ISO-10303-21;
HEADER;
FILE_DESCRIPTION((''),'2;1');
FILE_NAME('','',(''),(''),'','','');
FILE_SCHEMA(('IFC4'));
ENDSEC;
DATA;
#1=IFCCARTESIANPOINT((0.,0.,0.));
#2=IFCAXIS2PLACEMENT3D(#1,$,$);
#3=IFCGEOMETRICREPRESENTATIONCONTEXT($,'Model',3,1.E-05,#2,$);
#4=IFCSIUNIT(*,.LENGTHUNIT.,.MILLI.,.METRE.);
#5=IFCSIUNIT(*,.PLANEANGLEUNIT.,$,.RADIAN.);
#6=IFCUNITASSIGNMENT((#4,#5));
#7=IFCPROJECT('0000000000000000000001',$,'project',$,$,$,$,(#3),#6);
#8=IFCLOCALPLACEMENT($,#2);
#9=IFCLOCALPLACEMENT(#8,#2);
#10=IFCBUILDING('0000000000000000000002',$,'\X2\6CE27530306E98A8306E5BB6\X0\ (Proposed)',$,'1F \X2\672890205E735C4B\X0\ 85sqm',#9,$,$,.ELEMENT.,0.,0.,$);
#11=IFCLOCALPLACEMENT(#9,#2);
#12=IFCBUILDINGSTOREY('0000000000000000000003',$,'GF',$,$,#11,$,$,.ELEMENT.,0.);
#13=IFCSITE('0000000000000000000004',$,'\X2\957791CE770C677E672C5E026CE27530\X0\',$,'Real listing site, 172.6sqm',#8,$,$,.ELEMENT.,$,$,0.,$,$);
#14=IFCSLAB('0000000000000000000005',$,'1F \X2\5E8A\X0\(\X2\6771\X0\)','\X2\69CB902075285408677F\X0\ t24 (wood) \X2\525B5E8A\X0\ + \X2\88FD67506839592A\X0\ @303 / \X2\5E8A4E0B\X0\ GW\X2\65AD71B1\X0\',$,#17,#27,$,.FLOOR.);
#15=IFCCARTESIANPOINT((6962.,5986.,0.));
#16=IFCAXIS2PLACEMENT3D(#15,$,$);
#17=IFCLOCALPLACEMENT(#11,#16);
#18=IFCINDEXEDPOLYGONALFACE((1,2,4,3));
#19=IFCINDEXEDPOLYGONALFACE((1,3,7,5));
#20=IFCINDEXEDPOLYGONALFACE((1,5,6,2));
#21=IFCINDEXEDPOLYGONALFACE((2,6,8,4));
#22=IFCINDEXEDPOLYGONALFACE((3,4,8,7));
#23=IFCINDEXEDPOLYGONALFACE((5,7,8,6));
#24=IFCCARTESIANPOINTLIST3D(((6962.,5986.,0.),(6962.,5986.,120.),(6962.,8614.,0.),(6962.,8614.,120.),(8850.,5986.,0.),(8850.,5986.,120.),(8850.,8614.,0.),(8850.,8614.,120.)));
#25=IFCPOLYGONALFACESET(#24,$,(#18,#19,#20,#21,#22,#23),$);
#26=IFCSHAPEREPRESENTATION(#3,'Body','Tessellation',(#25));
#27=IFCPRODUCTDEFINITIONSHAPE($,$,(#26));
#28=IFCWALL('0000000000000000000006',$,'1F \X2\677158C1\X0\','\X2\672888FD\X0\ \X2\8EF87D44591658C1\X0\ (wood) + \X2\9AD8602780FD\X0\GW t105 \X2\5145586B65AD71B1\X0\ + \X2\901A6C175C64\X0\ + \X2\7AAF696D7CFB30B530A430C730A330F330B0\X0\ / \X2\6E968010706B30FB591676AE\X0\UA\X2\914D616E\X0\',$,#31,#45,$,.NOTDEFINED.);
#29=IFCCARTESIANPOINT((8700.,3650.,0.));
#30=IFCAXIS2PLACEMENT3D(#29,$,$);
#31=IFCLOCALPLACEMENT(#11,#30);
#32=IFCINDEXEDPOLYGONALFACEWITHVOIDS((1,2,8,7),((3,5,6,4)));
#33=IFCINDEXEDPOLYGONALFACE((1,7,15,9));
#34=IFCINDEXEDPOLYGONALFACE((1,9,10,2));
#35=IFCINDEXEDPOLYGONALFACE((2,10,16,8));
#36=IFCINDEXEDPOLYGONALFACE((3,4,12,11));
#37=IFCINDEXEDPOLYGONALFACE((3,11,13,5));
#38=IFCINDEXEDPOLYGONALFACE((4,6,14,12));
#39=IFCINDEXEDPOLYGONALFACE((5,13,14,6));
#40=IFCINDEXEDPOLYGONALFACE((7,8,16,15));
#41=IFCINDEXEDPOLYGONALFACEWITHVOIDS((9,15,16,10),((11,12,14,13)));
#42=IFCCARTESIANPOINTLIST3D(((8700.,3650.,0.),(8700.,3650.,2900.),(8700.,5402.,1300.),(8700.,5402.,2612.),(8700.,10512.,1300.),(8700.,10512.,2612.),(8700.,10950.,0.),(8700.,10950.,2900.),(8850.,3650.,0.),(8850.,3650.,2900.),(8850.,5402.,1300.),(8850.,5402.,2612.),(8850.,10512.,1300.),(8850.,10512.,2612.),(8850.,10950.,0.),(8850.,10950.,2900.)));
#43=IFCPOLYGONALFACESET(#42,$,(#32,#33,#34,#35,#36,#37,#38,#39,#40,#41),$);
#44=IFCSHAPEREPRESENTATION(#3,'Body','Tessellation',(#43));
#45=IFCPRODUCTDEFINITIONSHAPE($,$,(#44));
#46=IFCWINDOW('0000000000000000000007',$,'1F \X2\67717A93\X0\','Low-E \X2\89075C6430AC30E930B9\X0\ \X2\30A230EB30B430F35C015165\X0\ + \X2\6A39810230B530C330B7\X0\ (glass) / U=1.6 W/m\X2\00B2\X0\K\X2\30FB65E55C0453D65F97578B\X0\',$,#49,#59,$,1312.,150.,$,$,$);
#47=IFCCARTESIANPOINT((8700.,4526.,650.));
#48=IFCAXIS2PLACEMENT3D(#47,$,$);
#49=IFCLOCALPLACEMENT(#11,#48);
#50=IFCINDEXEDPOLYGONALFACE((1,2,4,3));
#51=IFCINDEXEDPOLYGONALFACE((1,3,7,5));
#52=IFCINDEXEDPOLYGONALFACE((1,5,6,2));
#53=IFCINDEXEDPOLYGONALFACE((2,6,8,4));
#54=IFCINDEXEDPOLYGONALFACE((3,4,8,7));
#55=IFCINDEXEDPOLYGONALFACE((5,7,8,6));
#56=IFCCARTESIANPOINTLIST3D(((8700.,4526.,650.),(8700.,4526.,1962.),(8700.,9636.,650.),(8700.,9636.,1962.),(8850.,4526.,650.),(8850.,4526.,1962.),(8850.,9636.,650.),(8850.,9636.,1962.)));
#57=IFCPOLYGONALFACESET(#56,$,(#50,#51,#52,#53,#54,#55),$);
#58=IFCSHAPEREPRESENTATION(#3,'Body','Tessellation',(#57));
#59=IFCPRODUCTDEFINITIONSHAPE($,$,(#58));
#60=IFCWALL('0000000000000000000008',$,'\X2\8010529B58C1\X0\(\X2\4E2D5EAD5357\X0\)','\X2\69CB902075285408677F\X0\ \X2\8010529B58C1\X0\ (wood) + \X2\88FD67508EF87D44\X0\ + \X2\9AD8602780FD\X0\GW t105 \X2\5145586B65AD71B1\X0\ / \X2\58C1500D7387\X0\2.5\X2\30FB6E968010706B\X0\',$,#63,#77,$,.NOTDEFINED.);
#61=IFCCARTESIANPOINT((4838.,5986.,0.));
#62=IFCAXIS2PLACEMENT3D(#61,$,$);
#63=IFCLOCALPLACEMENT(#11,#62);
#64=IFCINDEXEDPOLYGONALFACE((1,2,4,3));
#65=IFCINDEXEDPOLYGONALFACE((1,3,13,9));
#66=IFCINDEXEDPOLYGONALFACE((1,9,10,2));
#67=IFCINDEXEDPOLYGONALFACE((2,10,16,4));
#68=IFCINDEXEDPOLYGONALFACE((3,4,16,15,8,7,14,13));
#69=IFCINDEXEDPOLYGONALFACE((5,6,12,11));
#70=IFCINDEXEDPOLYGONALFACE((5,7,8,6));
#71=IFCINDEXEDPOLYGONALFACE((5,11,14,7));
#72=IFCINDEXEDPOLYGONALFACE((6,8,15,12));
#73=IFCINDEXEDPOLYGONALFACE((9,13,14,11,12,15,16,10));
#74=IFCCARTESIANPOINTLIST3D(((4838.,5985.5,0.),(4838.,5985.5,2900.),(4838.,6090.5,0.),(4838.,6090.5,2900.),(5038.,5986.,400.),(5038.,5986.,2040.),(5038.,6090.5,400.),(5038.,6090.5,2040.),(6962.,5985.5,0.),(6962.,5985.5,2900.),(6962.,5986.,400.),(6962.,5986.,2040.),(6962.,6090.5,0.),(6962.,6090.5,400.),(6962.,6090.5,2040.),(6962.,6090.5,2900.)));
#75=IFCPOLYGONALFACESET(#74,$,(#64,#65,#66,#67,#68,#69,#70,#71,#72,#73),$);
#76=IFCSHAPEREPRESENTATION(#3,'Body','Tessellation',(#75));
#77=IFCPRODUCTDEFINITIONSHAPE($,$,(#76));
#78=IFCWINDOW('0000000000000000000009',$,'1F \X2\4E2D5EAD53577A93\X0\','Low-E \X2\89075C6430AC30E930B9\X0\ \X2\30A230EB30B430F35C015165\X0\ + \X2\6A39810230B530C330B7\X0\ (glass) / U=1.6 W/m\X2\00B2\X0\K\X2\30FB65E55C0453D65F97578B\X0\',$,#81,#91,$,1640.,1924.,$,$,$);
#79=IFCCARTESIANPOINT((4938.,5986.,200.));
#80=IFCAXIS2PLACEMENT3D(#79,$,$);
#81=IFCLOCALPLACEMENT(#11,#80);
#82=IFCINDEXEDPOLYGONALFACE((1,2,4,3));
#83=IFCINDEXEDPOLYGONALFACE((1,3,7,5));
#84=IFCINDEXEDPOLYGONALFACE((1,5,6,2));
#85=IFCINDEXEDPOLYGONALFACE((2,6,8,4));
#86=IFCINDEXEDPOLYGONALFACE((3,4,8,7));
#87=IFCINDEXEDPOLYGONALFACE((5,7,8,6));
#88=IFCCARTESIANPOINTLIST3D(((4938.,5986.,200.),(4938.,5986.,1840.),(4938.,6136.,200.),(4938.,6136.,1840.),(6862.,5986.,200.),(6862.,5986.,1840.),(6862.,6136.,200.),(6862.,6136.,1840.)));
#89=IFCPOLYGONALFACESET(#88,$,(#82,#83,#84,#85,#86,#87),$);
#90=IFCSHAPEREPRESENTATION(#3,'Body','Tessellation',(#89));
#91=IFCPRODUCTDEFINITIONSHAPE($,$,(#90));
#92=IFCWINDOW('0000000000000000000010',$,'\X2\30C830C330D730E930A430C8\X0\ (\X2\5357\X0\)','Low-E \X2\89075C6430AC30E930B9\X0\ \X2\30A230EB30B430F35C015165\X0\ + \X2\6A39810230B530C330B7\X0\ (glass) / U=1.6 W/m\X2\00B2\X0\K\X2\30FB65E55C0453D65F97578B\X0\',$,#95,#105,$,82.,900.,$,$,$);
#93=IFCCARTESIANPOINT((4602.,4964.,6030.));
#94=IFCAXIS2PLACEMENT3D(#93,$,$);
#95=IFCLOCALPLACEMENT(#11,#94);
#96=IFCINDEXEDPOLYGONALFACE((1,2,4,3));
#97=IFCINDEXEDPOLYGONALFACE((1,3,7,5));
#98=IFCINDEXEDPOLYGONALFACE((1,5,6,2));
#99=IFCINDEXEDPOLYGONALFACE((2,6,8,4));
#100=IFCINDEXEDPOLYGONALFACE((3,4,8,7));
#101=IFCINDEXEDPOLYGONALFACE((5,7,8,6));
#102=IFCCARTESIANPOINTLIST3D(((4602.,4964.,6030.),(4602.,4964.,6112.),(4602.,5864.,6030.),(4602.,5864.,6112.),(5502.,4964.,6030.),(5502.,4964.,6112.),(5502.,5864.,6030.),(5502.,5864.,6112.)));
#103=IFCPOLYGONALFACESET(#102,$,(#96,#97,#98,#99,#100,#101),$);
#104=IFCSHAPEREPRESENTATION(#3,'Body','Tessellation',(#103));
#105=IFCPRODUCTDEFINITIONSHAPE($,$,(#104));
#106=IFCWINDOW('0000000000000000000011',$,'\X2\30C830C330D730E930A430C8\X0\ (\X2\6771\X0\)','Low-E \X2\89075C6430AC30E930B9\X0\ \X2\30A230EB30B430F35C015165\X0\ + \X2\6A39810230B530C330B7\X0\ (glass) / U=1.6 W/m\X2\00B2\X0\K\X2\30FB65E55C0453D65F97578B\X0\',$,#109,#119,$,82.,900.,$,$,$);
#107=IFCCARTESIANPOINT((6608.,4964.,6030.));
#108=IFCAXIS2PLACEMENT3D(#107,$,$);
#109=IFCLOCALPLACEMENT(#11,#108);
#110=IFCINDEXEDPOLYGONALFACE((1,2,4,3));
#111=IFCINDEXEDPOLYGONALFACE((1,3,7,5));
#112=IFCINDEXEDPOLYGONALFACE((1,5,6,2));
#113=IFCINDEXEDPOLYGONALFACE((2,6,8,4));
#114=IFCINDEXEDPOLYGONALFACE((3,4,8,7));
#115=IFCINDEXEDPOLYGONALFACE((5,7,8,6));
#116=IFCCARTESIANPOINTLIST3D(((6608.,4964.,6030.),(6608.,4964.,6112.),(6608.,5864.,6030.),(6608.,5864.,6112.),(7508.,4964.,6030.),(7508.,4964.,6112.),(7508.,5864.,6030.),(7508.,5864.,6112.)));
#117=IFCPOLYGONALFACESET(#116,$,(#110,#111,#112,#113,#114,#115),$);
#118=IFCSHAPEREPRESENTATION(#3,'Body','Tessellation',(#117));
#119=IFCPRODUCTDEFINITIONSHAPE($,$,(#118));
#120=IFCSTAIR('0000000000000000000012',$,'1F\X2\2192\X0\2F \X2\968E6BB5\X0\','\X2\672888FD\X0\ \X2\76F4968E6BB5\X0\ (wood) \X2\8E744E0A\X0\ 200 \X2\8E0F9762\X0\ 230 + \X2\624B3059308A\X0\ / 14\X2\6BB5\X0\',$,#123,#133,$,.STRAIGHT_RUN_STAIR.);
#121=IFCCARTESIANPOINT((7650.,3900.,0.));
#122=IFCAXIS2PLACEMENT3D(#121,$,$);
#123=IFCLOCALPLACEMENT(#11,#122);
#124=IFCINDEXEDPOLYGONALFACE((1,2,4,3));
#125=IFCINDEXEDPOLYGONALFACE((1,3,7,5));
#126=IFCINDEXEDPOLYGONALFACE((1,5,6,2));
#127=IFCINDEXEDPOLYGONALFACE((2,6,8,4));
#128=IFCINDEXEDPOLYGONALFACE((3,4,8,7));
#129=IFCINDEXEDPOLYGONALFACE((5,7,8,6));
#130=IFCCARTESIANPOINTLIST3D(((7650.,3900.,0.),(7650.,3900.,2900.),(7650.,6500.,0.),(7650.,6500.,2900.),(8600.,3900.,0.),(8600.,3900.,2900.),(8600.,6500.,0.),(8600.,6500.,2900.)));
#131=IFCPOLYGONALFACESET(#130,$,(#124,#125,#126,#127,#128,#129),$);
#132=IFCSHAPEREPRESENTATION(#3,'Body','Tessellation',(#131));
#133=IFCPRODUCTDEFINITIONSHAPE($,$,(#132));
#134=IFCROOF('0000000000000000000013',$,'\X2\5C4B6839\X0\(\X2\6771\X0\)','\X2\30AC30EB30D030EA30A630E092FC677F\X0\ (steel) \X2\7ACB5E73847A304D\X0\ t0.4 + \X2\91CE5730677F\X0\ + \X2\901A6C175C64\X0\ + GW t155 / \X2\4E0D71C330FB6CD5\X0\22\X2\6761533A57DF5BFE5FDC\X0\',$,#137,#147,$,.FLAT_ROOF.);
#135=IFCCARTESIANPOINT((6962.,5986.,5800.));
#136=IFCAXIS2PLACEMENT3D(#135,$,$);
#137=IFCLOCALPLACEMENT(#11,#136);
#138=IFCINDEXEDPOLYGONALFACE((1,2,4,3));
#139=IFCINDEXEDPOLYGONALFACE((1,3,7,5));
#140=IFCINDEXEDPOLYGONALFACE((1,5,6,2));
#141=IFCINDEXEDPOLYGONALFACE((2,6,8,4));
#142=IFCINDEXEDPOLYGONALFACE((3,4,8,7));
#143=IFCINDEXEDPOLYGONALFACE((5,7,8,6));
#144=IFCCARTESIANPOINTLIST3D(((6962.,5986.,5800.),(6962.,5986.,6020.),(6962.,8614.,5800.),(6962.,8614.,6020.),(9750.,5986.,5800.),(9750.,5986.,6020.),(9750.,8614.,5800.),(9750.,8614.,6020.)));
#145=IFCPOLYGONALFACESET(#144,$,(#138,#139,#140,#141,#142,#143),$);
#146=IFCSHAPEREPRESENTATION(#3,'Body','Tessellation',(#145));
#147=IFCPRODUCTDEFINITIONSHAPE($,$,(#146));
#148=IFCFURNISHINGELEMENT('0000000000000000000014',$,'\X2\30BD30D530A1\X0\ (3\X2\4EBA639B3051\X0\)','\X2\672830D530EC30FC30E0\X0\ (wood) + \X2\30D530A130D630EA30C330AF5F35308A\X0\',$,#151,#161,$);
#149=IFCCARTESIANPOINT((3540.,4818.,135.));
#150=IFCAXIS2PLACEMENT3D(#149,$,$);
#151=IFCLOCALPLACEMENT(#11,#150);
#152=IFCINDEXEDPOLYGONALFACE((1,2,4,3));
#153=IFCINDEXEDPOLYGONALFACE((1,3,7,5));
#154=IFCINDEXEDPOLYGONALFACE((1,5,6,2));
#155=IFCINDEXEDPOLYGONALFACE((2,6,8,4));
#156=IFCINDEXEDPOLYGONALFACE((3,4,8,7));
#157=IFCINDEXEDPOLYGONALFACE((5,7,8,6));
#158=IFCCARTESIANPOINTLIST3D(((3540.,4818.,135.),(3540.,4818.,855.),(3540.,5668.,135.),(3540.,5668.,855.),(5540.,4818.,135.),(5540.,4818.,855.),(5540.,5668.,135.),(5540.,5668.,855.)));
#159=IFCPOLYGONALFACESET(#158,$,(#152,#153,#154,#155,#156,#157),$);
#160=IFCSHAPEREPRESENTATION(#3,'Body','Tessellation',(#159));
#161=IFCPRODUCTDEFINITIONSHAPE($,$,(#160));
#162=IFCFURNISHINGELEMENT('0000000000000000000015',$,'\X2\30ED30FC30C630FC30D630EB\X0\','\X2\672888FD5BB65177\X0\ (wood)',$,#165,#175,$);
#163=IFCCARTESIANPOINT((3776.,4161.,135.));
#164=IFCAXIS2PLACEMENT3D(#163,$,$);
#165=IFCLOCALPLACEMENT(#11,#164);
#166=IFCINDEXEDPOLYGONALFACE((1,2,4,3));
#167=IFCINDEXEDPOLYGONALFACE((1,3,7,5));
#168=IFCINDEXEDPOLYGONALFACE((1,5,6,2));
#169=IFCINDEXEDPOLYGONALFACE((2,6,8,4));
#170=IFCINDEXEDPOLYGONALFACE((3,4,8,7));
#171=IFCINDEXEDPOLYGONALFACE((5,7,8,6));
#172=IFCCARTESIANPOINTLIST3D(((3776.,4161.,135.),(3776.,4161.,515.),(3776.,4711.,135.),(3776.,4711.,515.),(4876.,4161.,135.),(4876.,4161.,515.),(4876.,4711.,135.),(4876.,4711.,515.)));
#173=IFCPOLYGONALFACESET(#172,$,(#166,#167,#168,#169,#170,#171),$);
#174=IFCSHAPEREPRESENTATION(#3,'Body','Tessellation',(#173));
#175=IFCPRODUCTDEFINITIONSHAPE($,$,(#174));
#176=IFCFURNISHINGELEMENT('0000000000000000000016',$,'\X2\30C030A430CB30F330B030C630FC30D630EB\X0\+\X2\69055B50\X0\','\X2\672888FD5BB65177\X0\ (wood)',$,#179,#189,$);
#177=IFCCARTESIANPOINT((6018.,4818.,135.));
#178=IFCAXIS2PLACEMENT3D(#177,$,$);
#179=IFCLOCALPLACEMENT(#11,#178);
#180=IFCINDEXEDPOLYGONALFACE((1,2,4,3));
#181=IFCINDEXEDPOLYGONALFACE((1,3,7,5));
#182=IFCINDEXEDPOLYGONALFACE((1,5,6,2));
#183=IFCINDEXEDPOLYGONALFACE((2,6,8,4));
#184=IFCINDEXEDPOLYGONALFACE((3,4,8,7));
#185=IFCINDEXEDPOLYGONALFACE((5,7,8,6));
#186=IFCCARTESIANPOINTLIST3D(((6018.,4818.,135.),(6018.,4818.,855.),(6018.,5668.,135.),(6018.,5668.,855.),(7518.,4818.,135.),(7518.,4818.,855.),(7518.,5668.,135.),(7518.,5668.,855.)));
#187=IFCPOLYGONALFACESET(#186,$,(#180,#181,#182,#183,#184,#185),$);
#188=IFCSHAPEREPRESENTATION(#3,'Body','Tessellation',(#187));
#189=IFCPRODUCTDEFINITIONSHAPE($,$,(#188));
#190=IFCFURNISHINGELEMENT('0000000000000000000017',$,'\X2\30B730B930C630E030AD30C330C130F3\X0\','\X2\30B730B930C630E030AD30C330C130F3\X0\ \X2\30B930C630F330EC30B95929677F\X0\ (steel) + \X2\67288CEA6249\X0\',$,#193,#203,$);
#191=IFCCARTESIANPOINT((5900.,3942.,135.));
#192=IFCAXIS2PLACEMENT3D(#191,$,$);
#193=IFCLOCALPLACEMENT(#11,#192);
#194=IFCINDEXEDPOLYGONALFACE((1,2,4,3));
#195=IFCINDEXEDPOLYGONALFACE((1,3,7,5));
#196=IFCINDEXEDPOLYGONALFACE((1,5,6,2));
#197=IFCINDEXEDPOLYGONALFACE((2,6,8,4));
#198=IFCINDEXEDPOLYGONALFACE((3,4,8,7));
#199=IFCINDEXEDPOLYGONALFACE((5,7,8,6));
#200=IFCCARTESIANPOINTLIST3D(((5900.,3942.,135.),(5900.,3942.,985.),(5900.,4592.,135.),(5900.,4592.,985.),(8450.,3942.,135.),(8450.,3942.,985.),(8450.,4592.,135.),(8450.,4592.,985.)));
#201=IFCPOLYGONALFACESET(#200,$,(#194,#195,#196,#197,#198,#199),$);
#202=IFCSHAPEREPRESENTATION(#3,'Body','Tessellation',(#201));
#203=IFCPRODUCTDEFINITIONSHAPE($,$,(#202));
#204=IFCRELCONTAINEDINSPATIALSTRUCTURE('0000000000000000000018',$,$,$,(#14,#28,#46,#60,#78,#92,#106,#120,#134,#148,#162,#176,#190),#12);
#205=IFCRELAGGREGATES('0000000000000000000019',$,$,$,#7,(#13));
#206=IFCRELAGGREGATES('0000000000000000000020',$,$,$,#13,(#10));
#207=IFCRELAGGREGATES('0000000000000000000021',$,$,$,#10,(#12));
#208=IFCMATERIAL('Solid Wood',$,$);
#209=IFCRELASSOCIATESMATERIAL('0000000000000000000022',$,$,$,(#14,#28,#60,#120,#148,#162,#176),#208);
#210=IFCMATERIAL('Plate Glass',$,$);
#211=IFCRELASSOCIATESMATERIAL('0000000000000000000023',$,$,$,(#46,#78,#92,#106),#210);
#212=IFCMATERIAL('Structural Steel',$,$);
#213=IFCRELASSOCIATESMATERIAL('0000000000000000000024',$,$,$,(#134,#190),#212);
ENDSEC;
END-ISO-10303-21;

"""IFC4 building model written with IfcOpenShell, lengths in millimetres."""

from ifc_helpers import new_model, si_unit, frame, frame_2d, origin, place, context, project, spatial, rectangle, extrude, material, element, fill, save


model = new_model("IFC4")

# Units and contexts
model_context = context("Model", 3, precision=1e-05, world=origin())
ifc_project = project(units=[si_unit("LENGTHUNIT", "METRE", prefix="MILLI"), si_unit("PLANEANGLEUNIT", "RADIAN")], contexts=[model_context])

# Site, building, storey
site_placement = place(None, origin())
site = spatial("IfcSite", under=ifc_project, at=site_placement, Name="長野県松本市波田", ObjectType="Real listing site, 172.6sqm", CompositionType="ELEMENT", RefElevation=0.0)
building_placement = place(site_placement, origin())
building = spatial("IfcBuilding", under=site, at=building_placement, Name="波田の風の家 (Proposed)", ObjectType="1F 木造平屋 85sqm", CompositionType="ELEMENT", ElevationOfRefHeight=0.0, ElevationOfTerrain=0.0)
storey_placement = place(building_placement, origin())
storey = spatial("IfcBuildingStorey", under=building, at=storey_placement, Name="GF", CompositionType="ELEMENT", Elevation=0.0)

# Slab
ifc_material_1 = material(Name="Solid Wood")
slab_placement = place(storey_placement, frame((6962.0, 5986.0, 0.0)))
element("IfcSlab", 1, at=slab_placement, inside=storey, material=ifc_material_1, Name="1F 床(東)", Description="構造用合板 t24 (wood) 剛床 + 製材根太 @303 / 床下 GW断熱", PredefinedType="FLOOR", context=model_context, shape_type="SweptSolid", body=[
    extrude(rectangle(XDim=1888.0, YDim=2628.0, at=frame_2d((944.0, 1314.0))), frame((6962.0, 5986.0, 0.0)), (0.0, 0.0, 1.0), 120.0),
])

# Walls, openings, windows
wall_1_placement = place(storey_placement, frame((8700.0, 3650.0, 0.0)))
wall_1 = element("IfcWall", 2, at=wall_1_placement, inside=storey, material=ifc_material_1, Name="1F 東壁", Description="木製 軸組外壁 (wood) + 高性能GW t105 充填断熱 + 通気層 + 窯業系サイディング / 準耐火・外皮UA配慮", PredefinedType="NOTDEFINED", context=model_context, shape_type="SweptSolid", body=[
    extrude(rectangle(XDim=150.0, YDim=7300.0, at=frame_2d((75.0, 3650.0))), frame((8700.0, 3650.0, 0.0)), (0.0, 0.0, 1.0), 2900.0),
])
opening_1_placement = place(storey_placement, frame((8700.0, 4526.0, 650.0)))
opening_1 = element("IfcOpeningElement", 3, at=opening_1_placement, cuts=wall_1, PredefinedType="NOTDEFINED", context=model_context, shape_type="SweptSolid", body=[
    extrude(rectangle(XDim=150.0, YDim=5110.0, at=frame_2d((75.0, 2555.0))), frame((8700.0, 4526.0, 650.0)), (0.0, 0.0, 1.0), 1312.0),
])
ifc_material_2 = material(Name="Plate Glass")
window_1_placement = place(storey_placement, frame((8700.0, 4526.0, 650.0)))
window_1 = element("IfcWindow", 4, at=window_1_placement, inside=storey, material=ifc_material_2, Name="1F 東窓", Description="Low-E 複層ガラス アルゴン封入 + 樹脂サッシ (glass) / U=1.6 W/m²K・日射取得型", OverallHeight=1312.0, OverallWidth=150.0, context=model_context, shape_type="SweptSolid", body=[
    extrude(rectangle(XDim=150.0, YDim=5110.0, at=frame_2d((75.0, 2555.0))), frame((8700.0, 4526.0, 650.0)), (0.0, 0.0, 1.0), 1312.0),
])
fill(opening_1, window_1)
wall_2_placement = place(storey_placement, frame((4838.0, 5986.0, 0.0)))
wall_2 = element("IfcWall", 5, at=wall_2_placement, inside=storey, material=ifc_material_1, Name="耐力壁(中庭南)", Description="構造用合板 耐力壁 (wood) + 製材軸組 + 高性能GW t105 充填断熱 / 壁倍率2.5・準耐火", PredefinedType="NOTDEFINED", context=model_context, shape_type="SweptSolid", body=[
    extrude(rectangle(XDim=2124.0, YDim=105.0, at=frame_2d((1062.0, 52.0))), frame((4838.0, 5986.0, 0.0)), (0.0, 0.0, 1.0), 2900.0),
])
opening_2_placement = place(storey_placement, frame((4938.0, 5986.0, 200.0)))
opening_2 = element("IfcOpeningElement", 6, at=opening_2_placement, cuts=wall_2, PredefinedType="NOTDEFINED", context=model_context, shape_type="SweptSolid", body=[
    extrude(rectangle(XDim=1924.0, YDim=150.0, at=frame_2d((962.0, 75.0))), frame((4938.0, 5986.0, 200.0)), (0.0, 0.0, 1.0), 1640.0),
])
window_2_placement = place(storey_placement, frame((4938.0, 5986.0, 200.0)))
window_2 = element("IfcWindow", 7, at=window_2_placement, inside=storey, material=ifc_material_2, Name="1F 中庭南窓", Description="Low-E 複層ガラス アルゴン封入 + 樹脂サッシ (glass) / U=1.6 W/m²K・日射取得型", OverallHeight=1640.0, OverallWidth=1924.0, context=model_context, shape_type="SweptSolid", body=[
    extrude(rectangle(XDim=1924.0, YDim=150.0, at=frame_2d((962.0, 75.0))), frame((4938.0, 5986.0, 200.0)), (0.0, 0.0, 1.0), 1640.0),
])
fill(opening_2, window_2)

# Windows
window_3_placement = place(storey_placement, frame((4602.0, 4964.0, 6030.0)))
element("IfcWindow", 8, at=window_3_placement, inside=storey, material=ifc_material_2, Name="トップライト (南)", Description="Low-E 複層ガラス アルゴン封入 + 樹脂サッシ (glass) / U=1.6 W/m²K・日射取得型", OverallHeight=82.0, OverallWidth=900.0, context=model_context, shape_type="SweptSolid", body=[
    extrude(rectangle(XDim=900.0, YDim=900.0, at=frame_2d((450.0, 450.0))), frame((4602.0, 4964.0, 6030.0)), (0.0, 0.0, 1.0), 82.0),
])
window_4_placement = place(storey_placement, frame((6608.0, 4964.0, 6030.0)))
element("IfcWindow", 9, at=window_4_placement, inside=storey, material=ifc_material_2, Name="トップライト (東)", Description="Low-E 複層ガラス アルゴン封入 + 樹脂サッシ (glass) / U=1.6 W/m²K・日射取得型", OverallHeight=82.0, OverallWidth=900.0, context=model_context, shape_type="SweptSolid", body=[
    extrude(rectangle(XDim=900.0, YDim=900.0, at=frame_2d((450.0, 450.0))), frame((6608.0, 4964.0, 6030.0)), (0.0, 0.0, 1.0), 82.0),
])

# Stair
stair_placement = place(storey_placement, frame((7650.0, 3900.0, 0.0)))
element("IfcStair", 10, at=stair_placement, inside=storey, material=ifc_material_1, Name="1F→2F 階段", Description="木製 直階段 (wood) 蹴上 200 踏面 230 + 手すり / 14段", PredefinedType="STRAIGHT_RUN_STAIR", context=model_context, shape_type="SweptSolid", body=[
    extrude(rectangle(XDim=950.0, YDim=2600.0, at=frame_2d((475.0, 1300.0))), frame((7650.0, 3900.0, 0.0)), (0.0, 0.0, 1.0), 2900.0),
])

# Roof
ifc_material_3 = material(Name="Structural Steel")
roof_placement = place(storey_placement, frame((6962.0, 5986.0, 5800.0)))
element("IfcRoof", 11, at=roof_placement, inside=storey, material=ifc_material_3, Name="屋根(東)", Description="ガルバリウム鋼板 (steel) 立平葺き t0.4 + 野地板 + 通気層 + GW t155 / 不燃・法22条区域対応", PredefinedType="FLAT_ROOF", context=model_context, shape_type="SweptSolid", body=[
    extrude(rectangle(XDim=2788.0, YDim=2628.0, at=frame_2d((1394.0, 1314.0))), frame((6962.0, 5986.0, 5800.0)), (0.0, 0.0, 1.0), 220.0),
])

# Furnishing elements
furnishing_1_placement = place(storey_placement, frame((3540.0, 4818.0, 135.0)))
element("IfcFurnishingElement", 12, at=furnishing_1_placement, inside=storey, material=ifc_material_1, Name="ソファ (3人掛け)", Description="木フレーム (wood) + ファブリック張り", context=model_context, shape_type="SweptSolid", body=[
    extrude(rectangle(XDim=2000.0, YDim=850.0, at=frame_2d((1000.0, 425.0))), frame((3540.0, 4818.0, 135.0)), (0.0, 0.0, 1.0), 720.0),
])
furnishing_2_placement = place(storey_placement, frame((3776.0, 4161.0, 135.0)))
element("IfcFurnishingElement", 13, at=furnishing_2_placement, inside=storey, material=ifc_material_1, Name="ローテーブル", Description="木製家具 (wood)", context=model_context, shape_type="SweptSolid", body=[
    extrude(rectangle(XDim=1100.0, YDim=550.0, at=frame_2d((550.0, 275.0))), frame((3776.0, 4161.0, 135.0)), (0.0, 0.0, 1.0), 380.0),
])
furnishing_3_placement = place(storey_placement, frame((6018.0, 4818.0, 135.0)))
element("IfcFurnishingElement", 14, at=furnishing_3_placement, inside=storey, material=ifc_material_1, Name="ダイニングテーブル+椅子", Description="木製家具 (wood)", context=model_context, shape_type="SweptSolid", body=[
    extrude(rectangle(XDim=1500.0, YDim=850.0, at=frame_2d((750.0, 425.0))), frame((6018.0, 4818.0, 135.0)), (0.0, 0.0, 1.0), 720.0),
])
furnishing_4_placement = place(storey_placement, frame((5900.0, 3942.0, 135.0)))
element("IfcFurnishingElement", 15, at=furnishing_4_placement, inside=storey, material=ifc_material_3, Name="システムキッチン", Description="システムキッチン ステンレス天板 (steel) + 木質扉", context=model_context, shape_type="SweptSolid", body=[
    extrude(rectangle(XDim=2550.0, YDim=650.0, at=frame_2d((1275.0, 325.0))), frame((5900.0, 3942.0, 135.0)), (0.0, 0.0, 1.0), 850.0),
])

save(model, "model.ifc")
